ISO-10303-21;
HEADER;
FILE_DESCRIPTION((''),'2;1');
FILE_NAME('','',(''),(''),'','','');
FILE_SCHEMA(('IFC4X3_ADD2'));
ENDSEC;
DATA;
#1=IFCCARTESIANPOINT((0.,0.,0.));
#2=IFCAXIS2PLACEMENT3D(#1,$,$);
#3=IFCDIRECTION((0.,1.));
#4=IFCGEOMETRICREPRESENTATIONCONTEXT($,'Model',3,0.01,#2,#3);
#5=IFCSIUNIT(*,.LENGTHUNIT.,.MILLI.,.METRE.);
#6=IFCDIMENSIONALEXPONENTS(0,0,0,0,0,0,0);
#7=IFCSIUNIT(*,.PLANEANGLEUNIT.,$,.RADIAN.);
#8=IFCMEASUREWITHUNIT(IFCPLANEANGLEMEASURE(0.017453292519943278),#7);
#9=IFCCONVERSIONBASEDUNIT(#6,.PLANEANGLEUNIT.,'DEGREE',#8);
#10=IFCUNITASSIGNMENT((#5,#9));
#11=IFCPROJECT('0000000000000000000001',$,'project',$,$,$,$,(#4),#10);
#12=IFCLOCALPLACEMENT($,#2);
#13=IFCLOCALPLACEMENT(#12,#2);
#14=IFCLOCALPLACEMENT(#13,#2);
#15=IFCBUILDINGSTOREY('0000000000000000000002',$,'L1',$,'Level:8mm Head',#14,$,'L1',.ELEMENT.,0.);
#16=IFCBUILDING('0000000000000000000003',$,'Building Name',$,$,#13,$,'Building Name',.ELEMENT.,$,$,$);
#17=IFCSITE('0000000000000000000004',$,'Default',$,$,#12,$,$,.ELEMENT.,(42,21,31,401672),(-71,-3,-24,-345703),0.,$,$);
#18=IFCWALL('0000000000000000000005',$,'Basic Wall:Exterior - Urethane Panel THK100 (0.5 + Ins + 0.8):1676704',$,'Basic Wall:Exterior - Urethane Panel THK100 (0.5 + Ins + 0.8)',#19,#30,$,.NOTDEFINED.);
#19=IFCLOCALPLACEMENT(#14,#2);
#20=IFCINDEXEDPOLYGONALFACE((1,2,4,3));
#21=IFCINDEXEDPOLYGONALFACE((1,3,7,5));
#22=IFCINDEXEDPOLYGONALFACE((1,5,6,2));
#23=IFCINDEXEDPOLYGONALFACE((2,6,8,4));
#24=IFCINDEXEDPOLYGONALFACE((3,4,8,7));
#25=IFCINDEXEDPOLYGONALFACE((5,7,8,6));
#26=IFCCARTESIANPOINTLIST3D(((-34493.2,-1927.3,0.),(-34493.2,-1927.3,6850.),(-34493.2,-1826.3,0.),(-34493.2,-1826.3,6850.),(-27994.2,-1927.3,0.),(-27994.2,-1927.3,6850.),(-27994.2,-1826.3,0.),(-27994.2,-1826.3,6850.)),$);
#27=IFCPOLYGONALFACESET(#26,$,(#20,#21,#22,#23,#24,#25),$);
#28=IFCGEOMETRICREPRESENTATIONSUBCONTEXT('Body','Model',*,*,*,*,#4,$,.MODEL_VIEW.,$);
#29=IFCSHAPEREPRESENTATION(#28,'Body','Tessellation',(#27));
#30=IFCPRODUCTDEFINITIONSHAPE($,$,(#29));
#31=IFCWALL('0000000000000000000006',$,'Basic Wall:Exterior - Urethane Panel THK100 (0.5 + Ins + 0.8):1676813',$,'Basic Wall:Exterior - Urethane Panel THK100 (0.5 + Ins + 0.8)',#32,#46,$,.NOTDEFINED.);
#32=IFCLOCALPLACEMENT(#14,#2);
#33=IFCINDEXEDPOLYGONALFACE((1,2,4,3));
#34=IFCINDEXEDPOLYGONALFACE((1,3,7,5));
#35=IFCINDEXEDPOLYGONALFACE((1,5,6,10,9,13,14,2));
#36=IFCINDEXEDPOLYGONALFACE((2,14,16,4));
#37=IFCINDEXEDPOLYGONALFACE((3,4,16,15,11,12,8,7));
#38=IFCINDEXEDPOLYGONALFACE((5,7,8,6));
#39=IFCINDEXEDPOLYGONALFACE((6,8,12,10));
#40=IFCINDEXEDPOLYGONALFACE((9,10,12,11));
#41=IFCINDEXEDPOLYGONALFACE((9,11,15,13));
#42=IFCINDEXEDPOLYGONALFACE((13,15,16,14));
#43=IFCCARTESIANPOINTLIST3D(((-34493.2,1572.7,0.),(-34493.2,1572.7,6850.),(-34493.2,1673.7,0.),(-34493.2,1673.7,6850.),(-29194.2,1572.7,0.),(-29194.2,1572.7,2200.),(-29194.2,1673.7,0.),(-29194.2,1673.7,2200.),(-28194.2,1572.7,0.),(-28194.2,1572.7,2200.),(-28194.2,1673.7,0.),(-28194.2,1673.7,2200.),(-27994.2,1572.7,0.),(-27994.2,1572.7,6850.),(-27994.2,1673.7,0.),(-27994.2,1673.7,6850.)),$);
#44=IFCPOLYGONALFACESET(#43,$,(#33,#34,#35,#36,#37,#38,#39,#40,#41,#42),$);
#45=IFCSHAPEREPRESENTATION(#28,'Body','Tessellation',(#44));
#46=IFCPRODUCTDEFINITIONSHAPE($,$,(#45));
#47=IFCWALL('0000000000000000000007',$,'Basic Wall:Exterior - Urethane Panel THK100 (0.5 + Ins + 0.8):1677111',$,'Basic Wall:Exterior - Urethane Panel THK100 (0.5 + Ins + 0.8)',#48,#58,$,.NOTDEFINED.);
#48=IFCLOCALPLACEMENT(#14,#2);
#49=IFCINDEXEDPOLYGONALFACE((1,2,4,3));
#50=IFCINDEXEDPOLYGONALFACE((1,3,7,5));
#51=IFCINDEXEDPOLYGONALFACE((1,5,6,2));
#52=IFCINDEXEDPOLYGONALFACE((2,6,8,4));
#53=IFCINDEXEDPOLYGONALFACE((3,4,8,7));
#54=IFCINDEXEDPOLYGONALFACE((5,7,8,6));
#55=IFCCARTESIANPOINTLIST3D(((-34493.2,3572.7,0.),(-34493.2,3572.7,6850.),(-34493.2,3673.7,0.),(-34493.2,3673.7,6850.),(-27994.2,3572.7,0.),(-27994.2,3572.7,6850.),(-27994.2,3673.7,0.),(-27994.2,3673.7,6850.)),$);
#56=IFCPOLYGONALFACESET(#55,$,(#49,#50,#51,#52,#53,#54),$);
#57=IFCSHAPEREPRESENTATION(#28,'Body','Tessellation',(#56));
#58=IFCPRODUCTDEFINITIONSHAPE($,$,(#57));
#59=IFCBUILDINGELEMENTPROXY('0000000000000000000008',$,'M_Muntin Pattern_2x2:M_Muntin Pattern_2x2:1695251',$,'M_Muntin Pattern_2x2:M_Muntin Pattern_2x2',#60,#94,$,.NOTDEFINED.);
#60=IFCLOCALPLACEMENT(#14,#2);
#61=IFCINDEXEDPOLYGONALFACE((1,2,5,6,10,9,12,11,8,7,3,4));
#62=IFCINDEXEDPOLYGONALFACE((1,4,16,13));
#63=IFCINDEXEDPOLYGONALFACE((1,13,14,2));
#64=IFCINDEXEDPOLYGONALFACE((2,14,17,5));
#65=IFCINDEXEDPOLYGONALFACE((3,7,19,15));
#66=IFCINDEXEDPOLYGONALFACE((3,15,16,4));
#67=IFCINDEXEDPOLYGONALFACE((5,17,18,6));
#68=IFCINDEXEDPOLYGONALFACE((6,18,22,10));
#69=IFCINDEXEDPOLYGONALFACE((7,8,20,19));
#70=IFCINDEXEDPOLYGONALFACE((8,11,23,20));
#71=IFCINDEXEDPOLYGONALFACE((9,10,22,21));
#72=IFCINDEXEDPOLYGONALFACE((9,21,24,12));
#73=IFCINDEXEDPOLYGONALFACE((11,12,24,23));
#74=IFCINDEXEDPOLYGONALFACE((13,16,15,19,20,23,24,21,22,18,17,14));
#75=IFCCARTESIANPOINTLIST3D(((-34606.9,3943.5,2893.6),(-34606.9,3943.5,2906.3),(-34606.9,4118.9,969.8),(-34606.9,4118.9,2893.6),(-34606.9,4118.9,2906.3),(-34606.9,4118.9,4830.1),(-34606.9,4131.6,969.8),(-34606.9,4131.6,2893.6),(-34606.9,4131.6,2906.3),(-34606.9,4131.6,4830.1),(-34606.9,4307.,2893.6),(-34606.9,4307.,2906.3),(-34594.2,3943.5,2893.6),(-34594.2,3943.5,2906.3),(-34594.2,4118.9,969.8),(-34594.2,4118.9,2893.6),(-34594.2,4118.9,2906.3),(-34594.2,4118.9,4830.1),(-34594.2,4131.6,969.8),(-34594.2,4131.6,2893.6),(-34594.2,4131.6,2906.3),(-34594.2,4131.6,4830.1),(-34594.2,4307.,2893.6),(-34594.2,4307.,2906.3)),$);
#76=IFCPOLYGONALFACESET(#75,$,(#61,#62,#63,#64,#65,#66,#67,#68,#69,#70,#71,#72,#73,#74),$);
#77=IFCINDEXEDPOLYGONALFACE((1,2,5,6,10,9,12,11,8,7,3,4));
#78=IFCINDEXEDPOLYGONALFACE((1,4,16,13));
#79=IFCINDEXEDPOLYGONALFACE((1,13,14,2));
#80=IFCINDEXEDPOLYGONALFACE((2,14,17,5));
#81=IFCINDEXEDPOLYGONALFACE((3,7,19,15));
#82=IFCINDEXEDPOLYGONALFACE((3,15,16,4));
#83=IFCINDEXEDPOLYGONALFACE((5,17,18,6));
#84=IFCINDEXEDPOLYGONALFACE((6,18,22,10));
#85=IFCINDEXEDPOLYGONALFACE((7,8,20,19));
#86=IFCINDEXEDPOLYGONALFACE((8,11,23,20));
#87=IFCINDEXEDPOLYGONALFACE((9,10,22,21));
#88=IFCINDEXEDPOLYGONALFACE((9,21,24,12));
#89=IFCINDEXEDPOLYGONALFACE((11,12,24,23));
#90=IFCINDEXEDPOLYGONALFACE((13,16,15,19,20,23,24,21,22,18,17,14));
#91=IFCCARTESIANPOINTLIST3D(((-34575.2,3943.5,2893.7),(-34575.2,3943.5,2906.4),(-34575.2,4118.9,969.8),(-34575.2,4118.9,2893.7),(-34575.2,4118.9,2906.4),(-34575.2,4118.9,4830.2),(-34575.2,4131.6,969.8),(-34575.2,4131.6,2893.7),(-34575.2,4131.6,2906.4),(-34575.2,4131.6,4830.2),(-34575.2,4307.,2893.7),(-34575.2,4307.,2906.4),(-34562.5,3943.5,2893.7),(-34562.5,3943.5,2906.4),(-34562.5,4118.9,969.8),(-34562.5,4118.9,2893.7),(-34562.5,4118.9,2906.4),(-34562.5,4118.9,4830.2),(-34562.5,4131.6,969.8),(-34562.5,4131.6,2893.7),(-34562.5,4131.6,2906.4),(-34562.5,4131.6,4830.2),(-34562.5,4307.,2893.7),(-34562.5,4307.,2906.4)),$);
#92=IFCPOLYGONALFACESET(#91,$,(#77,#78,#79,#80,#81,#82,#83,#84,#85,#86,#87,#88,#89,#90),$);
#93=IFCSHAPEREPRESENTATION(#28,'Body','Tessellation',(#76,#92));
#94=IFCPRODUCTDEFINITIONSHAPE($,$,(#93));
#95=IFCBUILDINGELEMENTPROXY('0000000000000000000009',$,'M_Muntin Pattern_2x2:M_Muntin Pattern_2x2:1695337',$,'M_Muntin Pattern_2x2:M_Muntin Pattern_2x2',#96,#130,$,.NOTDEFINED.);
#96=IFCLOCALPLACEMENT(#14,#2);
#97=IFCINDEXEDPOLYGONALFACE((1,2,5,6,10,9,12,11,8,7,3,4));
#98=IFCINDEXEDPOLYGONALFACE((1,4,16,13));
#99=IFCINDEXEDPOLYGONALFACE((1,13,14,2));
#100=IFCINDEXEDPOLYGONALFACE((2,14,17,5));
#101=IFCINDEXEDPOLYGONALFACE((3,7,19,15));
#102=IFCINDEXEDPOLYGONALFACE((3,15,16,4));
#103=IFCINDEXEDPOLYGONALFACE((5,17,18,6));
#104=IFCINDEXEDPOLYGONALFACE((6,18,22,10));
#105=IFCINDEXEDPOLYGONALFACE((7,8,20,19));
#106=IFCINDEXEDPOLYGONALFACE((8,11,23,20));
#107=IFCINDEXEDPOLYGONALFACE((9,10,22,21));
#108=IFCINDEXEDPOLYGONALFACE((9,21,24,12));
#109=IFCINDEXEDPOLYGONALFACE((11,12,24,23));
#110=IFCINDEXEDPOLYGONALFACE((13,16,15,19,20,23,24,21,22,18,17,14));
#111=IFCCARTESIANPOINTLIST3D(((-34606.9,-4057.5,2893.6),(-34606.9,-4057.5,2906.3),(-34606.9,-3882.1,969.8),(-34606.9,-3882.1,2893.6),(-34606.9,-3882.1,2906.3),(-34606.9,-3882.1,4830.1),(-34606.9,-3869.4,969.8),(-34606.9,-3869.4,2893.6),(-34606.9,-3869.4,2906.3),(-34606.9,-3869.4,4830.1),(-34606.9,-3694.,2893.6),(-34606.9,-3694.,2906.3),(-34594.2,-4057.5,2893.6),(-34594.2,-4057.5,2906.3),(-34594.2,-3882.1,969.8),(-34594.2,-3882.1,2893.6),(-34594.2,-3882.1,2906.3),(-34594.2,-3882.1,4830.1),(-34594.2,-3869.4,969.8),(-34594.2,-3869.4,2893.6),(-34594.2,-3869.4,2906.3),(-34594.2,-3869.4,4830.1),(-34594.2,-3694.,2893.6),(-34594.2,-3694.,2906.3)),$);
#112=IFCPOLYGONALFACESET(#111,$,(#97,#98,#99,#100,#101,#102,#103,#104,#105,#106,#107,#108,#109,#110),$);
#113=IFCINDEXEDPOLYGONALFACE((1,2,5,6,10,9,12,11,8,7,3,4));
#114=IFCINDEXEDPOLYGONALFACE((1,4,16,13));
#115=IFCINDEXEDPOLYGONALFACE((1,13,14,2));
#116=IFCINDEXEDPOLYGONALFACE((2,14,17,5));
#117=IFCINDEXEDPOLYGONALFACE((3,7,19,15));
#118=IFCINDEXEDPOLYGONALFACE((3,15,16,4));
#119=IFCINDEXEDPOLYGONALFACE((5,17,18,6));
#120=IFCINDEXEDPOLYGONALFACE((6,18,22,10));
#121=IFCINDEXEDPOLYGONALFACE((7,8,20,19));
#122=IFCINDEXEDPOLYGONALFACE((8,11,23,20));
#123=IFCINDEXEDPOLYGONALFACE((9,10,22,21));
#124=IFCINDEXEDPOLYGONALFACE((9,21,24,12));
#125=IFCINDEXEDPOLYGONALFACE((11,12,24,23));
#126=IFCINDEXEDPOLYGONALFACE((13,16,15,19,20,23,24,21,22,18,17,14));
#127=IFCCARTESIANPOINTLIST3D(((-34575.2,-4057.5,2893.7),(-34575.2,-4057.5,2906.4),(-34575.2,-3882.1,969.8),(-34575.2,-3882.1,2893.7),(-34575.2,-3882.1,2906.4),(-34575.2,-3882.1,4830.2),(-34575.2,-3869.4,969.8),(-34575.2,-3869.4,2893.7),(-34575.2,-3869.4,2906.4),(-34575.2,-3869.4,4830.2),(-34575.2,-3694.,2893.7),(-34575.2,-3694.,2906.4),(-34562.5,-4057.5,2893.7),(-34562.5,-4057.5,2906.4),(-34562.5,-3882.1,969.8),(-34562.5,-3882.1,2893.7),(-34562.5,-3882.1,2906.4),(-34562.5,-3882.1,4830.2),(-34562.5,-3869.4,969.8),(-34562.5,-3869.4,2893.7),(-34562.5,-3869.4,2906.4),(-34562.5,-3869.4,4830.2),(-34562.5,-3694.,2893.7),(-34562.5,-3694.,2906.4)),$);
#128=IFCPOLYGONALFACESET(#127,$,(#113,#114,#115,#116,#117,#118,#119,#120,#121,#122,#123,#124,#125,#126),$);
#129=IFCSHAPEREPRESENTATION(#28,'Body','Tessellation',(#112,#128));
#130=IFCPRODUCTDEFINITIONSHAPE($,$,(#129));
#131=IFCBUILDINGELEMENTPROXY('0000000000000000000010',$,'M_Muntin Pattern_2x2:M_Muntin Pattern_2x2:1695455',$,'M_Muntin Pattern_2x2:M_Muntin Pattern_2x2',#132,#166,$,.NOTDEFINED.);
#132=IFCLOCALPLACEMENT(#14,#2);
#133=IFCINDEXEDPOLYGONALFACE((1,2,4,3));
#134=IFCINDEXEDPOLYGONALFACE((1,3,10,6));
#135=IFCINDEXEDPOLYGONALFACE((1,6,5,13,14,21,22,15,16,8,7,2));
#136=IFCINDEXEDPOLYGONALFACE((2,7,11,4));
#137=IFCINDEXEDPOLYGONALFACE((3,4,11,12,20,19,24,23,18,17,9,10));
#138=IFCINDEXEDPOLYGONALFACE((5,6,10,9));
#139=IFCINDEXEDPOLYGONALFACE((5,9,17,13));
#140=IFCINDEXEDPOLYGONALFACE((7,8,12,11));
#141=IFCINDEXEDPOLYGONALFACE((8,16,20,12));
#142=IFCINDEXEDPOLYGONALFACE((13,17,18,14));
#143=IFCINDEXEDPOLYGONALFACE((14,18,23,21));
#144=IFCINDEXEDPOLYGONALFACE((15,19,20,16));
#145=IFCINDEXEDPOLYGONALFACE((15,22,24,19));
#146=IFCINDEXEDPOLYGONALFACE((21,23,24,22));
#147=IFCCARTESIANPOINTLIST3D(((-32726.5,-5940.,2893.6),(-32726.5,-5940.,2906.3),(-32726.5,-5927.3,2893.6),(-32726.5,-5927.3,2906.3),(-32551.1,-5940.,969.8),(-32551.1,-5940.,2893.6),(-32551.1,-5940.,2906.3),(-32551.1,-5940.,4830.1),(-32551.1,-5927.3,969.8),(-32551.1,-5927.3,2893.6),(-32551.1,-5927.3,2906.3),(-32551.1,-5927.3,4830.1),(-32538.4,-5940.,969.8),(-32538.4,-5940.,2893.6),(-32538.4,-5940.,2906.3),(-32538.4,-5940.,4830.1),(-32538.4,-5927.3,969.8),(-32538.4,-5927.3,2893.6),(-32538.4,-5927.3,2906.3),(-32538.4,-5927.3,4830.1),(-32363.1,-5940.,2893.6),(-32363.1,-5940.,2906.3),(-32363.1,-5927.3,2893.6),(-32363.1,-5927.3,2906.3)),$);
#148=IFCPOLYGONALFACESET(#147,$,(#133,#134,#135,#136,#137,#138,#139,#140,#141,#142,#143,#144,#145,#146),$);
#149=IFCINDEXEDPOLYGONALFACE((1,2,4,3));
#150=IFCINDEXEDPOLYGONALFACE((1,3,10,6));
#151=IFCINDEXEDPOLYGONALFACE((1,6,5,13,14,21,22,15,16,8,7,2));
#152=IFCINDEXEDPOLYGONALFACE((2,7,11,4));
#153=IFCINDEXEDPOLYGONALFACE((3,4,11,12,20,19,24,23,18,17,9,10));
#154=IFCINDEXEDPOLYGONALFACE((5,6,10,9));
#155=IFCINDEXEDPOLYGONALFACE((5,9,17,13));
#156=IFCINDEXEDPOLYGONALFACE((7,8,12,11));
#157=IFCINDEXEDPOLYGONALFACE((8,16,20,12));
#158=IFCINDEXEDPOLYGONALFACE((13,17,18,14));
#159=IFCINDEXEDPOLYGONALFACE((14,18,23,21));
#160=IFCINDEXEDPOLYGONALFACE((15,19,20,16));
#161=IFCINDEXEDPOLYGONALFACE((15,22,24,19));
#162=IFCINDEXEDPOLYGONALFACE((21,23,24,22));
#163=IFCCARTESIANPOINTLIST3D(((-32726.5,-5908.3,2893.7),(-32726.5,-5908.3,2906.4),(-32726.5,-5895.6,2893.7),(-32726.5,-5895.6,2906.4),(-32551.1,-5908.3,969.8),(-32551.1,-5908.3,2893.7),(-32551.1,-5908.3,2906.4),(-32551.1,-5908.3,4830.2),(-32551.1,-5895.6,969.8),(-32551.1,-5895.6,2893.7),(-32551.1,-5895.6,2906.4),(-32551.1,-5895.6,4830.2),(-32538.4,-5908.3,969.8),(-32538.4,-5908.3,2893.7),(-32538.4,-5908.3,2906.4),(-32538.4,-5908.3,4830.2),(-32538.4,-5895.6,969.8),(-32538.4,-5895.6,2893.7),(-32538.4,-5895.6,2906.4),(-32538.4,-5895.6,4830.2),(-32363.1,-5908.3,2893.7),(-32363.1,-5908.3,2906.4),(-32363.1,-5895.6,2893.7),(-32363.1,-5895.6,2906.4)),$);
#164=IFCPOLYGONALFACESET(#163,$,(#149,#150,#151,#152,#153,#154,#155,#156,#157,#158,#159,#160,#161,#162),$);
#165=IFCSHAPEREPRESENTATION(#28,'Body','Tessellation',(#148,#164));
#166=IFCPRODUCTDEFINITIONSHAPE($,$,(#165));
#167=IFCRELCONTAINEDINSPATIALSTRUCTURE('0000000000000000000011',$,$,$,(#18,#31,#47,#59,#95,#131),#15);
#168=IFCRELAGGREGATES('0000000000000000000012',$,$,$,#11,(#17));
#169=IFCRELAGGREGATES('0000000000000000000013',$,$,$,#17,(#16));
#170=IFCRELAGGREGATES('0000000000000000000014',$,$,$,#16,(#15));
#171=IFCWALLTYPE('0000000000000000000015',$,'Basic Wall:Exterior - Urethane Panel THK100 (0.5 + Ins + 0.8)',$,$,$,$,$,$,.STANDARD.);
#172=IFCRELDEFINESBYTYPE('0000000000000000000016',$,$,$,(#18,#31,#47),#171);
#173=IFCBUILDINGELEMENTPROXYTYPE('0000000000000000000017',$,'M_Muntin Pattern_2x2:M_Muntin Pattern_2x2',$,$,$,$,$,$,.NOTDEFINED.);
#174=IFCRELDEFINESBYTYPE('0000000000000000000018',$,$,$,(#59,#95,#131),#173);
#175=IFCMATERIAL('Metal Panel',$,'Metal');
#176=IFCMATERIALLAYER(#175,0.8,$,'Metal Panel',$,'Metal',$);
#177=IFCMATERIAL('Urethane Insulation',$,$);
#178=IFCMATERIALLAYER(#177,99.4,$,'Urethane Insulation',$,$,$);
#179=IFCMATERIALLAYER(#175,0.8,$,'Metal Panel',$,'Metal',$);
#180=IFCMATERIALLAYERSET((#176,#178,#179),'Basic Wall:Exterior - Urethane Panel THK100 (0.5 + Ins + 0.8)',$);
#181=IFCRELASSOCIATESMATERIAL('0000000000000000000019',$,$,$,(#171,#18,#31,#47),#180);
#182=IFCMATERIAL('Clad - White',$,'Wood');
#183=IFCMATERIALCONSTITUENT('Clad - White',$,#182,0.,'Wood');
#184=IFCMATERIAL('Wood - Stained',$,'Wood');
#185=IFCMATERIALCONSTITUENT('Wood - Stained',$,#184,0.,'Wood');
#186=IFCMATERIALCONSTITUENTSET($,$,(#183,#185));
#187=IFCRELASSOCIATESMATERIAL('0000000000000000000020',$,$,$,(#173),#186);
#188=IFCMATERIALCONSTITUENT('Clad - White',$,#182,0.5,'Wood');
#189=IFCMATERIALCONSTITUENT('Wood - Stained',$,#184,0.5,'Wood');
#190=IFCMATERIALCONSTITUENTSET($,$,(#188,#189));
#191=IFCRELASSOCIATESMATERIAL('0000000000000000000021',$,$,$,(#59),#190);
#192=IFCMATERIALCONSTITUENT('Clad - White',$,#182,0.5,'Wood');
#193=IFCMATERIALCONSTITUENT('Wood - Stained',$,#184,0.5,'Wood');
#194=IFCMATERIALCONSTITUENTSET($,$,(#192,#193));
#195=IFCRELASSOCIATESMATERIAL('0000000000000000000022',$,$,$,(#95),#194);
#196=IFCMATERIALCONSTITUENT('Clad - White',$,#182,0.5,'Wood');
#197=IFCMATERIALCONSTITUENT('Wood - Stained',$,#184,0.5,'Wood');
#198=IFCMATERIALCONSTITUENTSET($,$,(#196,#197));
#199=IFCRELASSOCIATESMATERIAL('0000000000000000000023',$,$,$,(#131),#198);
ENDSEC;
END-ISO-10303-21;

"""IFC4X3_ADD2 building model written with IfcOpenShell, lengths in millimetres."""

from ifc_helpers import new_model, entity, si_unit, converted_unit, direction, frame, frame_2d, origin, place, context, subcontext, project, spatial, polyline, rectangle, outline, extrude, clip, bounded_halfspace, source, transform, mapped, material, layer, layer_set, constituent, constituent_set, type_object, type_shapes, element, save


model = new_model("IFC4X3_ADD2")

# Units and contexts
model_context = context("Model", 3, precision=0.01, world=origin(), true_north=direction((0.0, 1.0)))
body_context = subcontext(model_context, "Body", "Model", "MODEL_VIEW")
ifc_project = project(units=[si_unit("LENGTHUNIT", "METRE", prefix="MILLI"), converted_unit("PLANEANGLEUNIT", "DEGREE", entity("IfcPlaneAngleMeasure", 0.017453292519943278), si_unit("PLANEANGLEUNIT", "RADIAN"), dimensions=[0, 0, 0, 0, 0, 0, 0])], contexts=[model_context])

# Site, building, storey
site_placement = place(None, origin())
site = spatial("IfcSite", under=ifc_project, at=site_placement, Name="Default", CompositionType="ELEMENT", RefLatitude=(42, 21, 31, 401672), RefLongitude=(-71, -3, -24, -345703), RefElevation=0.0)
building_placement = place(site_placement, origin())
building = spatial("IfcBuilding", under=site, at=building_placement, Name="Building Name", LongName="Building Name", CompositionType="ELEMENT")
storey_placement = place(building_placement, origin())
storey = spatial("IfcBuildingStorey", under=building, at=storey_placement, Name="L1", ObjectType="Level:8mm Head", LongName="L1", CompositionType="ELEMENT", Elevation=0.0)

# Shared definitions
ifc_material_1 = material(Name="Metal Panel", Category="Metal")
ifc_layer_1 = layer(ifc_material_1, 0.8, Name="Metal Panel", Category="Metal")
ifc_material_2 = material(Name="Urethane Insulation")
ifc_layer_2 = layer(ifc_material_2, 99.4, Name="Urethane Insulation")
ifc_layer_3 = layer(ifc_material_1, 0.8, Name="Metal Panel", Category="Metal")
ifc_layer_set = layer_set([ifc_layer_1, ifc_layer_2, ifc_layer_3], Name="Basic Wall:Exterior - Urethane Panel THK100 (0.5 + Ins + 0.8)")
wall_type = type_object("IfcWallType", Name="Basic Wall:Exterior - Urethane Panel THK100 (0.5 + Ins + 0.8)", PredefinedType="STANDARD", material=ifc_layer_set)

# Wall
wall_1_placement = place(storey_placement, frame((-34493.2, -1876.8, 0.0)))
element("IfcWall", 1, at=wall_1_placement, inside=storey, type_object=wall_type, material=ifc_layer_set, Name="Basic Wall:Exterior - Urethane Panel THK100 (0.5 + Ins + 0.8):1676704", ObjectType="Basic Wall:Exterior - Urethane Panel THK100 (0.5 + Ins + 0.8)", PredefinedType="NOTDEFINED", context=body_context, shape_type="Clipping", body=[
    clip(extrude(rectangle(XDim=6499.0, YDim=101.0, at=frame_2d((3249.5, 0.0), x_axis=(-1.0, 0.0))), origin(), (0.0, 0.0, 1.0), 6850.0), bounded_halfspace(frame((0.0, -50.5, 6850.0), z_axis=(0.0, 0.0, -1.0), x_axis=(1.0, 0.0, 0.0)), True, frame((0.0, -50.5, 6850.0)), polyline([(0.0, 0.0), (6499.0, 0.0), (6499.0, 101.0), (0.0, 101.0), (0.0, 0.0)]))),
])

# Wall, opening
wall_2_placement = place(storey_placement, frame((-34493.2, 1623.2, 0.0)))
wall_2 = element("IfcWall", 2, at=wall_2_placement, inside=storey, type_object=wall_type, material=ifc_layer_set, Name="Basic Wall:Exterior - Urethane Panel THK100 (0.5 + Ins + 0.8):1676813", ObjectType="Basic Wall:Exterior - Urethane Panel THK100 (0.5 + Ins + 0.8)", PredefinedType="NOTDEFINED", context=body_context, shape_type="Clipping", body=[
    clip(extrude(rectangle(XDim=6499.0, YDim=101.0, at=frame_2d((3249.5, 0.0), x_axis=(1.0, 0.0))), origin(), (0.0, 0.0, 1.0), 6850.0), bounded_halfspace(frame((0.0, -50.5, 6850.0), z_axis=(0.0, 0.0, -1.0), x_axis=(1.0, 0.0, 0.0)), True, frame((0.0, -50.5, 6850.0)), polyline([(0.0, 0.0), (6499.0, 0.0), (6499.0, 101.0), (0.0, 101.0), (0.0, 0.0)]))),
])
opening_1_placement = place(wall_2_placement, frame((5299.0, -50.5, 0.0)))
element("IfcOpeningElement", 3, at=opening_1_placement, cuts=wall_2, PredefinedType="OPENING", context=body_context, shape_type="SweptSolid", body=[
    extrude(rectangle(XDim=2200.0, YDim=1000.0, at=frame_2d((1100.0, 500.0), x_axis=(1.0, 0.0))), frame((0.0, 0.0, 0.0), z_axis=(0.0, 1.0, 0.0), x_axis=(0.0, 0.0, 1.0)), (0.0, 0.0, 1.0), 101.0),
])

# Wall
wall_3_placement = place(storey_placement, frame((-34493.2, 3623.2, 0.0)))
element("IfcWall", 4, at=wall_3_placement, inside=storey, type_object=wall_type, material=ifc_layer_set, Name="Basic Wall:Exterior - Urethane Panel THK100 (0.5 + Ins + 0.8):1677111", ObjectType="Basic Wall:Exterior - Urethane Panel THK100 (0.5 + Ins + 0.8)", PredefinedType="NOTDEFINED", context=body_context, shape_type="Clipping", body=[
    clip(extrude(rectangle(XDim=6499.0, YDim=101.0, at=frame_2d((3249.5, 0.0), x_axis=(-1.0, 0.0))), origin(), (0.0, 0.0, 1.0), 6850.0), bounded_halfspace(frame((0.0, -50.5, 6850.0), z_axis=(0.0, 0.0, -1.0), x_axis=(1.0, 0.0, 0.0)), True, frame((0.0, -50.5, 6850.0)), polyline([(0.0, 0.0), (6499.0, 0.0), (6499.0, 101.0), (0.0, 101.0), (0.0, 0.0)]))),
])

# Building element proxies
ifc_material_3 = material(Name="Clad - White", Category="Wood")
ifc_constituent_1 = constituent(ifc_material_3, Name="Clad - White", Category="Wood", fraction=0.5)
ifc_material_4 = material(Name="Wood - Stained", Category="Wood")
ifc_constituent_2 = constituent(ifc_material_4, Name="Wood - Stained", Category="Wood", fraction=0.5)
ifc_constituent_set_1 = constituent_set(constituents=[ifc_constituent_1, ifc_constituent_2])
ifc_constituent_3 = constituent(ifc_material_3, Name="Clad - White", Category="Wood", fraction=0.0)
ifc_constituent_4 = constituent(ifc_material_4, Name="Wood - Stained", Category="Wood", fraction=0.0)
ifc_constituent_set_2 = constituent_set(constituents=[ifc_constituent_3, ifc_constituent_4])
building_element_proxy_type_1 = type_object("IfcBuildingElementProxyType", Name="M_Muntin Pattern_2x2:M_Muntin Pattern_2x2", PredefinedType="NOTDEFINED", material=ifc_constituent_set_2)
shared_shape_1 = source(origin(), body_context, "Body", "SweptSolid", [
    extrude(outline(polyline([(6.4, -6.4), (1930.1, -6.4), (1930.1, 6.3), (6.4, 6.3), (6.4, 181.7), (-6.3, 181.7), (-6.3, 6.3), (-1930.2, 6.3), (-1930.2, -6.4), (-6.3, -6.4), (-6.3, -181.7), (6.4, -181.7), (6.4, -6.4)])), frame((0.0, 9.5, 1930.1), z_axis=(0.0, 1.0, 0.0), x_axis=(0.0, 0.0, 1.0)), (0.0, 0.0, 1.0), 12.7),
    extrude(outline(polyline([(6.4, -6.4), (1930.2, -6.4), (1930.2, 6.3), (6.4, 6.3), (6.4, 181.7), (-6.3, 181.7), (-6.3, 6.3), (-1930.2, 6.3), (-1930.2, -6.4), (-6.3, -6.4), (-6.3, -181.7), (6.4, -181.7), (6.4, -6.4)])), frame((0.0, -22.2, 1930.2), z_axis=(0.0, 1.0, 0.0), x_axis=(0.0, 0.0, 1.0)), (0.0, 0.0, 1.0), 12.7),
])
type_shapes(building_element_proxy_type_1, [shared_shape_1])
proxy_1_placement = place(storey_placement, frame((-34584.7, 4125.3, 969.8), z_axis=(0.0, 0.0, 1.0), x_axis=(0.0, 1.0, 0.0)))
element("IfcBuildingElementProxy", 5, at=proxy_1_placement, inside=storey, type_object=building_element_proxy_type_1, material=ifc_constituent_set_1, Name="M_Muntin Pattern_2x2:M_Muntin Pattern_2x2:1695251", ObjectType="M_Muntin Pattern_2x2:M_Muntin Pattern_2x2", PredefinedType="NOTDEFINED", context=body_context, shape_type="MappedRepresentation", body=[
    mapped(shared_shape_1, transform((0.0, 0.0, 0.0), scale=1.0)),
])
ifc_constituent_5 = constituent(ifc_material_3, Name="Clad - White", Category="Wood", fraction=0.5)
ifc_constituent_6 = constituent(ifc_material_4, Name="Wood - Stained", Category="Wood", fraction=0.5)
ifc_constituent_set_3 = constituent_set(constituents=[ifc_constituent_5, ifc_constituent_6])
proxy_2_placement = place(storey_placement, frame((-34584.7, -3875.7, 969.8), z_axis=(0.0, 0.0, 1.0), x_axis=(0.0, 1.0, 0.0)))
element("IfcBuildingElementProxy", 6, at=proxy_2_placement, inside=storey, type_object=building_element_proxy_type_1, material=ifc_constituent_set_3, Name="M_Muntin Pattern_2x2:M_Muntin Pattern_2x2:1695337", ObjectType="M_Muntin Pattern_2x2:M_Muntin Pattern_2x2", PredefinedType="NOTDEFINED", context=body_context, shape_type="MappedRepresentation", body=[
    mapped(shared_shape_1, transform((0.0, 0.0, 0.0), scale=1.0)),
])
ifc_constituent_7 = constituent(ifc_material_3, Name="Clad - White", Category="Wood", fraction=0.5)
ifc_constituent_8 = constituent(ifc_material_4, Name="Wood - Stained", Category="Wood", fraction=0.5)
ifc_constituent_set_4 = constituent_set(constituents=[ifc_constituent_7, ifc_constituent_8])
proxy_3_placement = place(storey_placement, frame((-32544.8, -5917.8, 969.8), z_axis=(0.0, 0.0, 1.0), x_axis=(-1.0, 0.0, 0.0)))
element("IfcBuildingElementProxy", 7, at=proxy_3_placement, inside=storey, type_object=building_element_proxy_type_1, material=ifc_constituent_set_4, Name="M_Muntin Pattern_2x2:M_Muntin Pattern_2x2:1695455", ObjectType="M_Muntin Pattern_2x2:M_Muntin Pattern_2x2", PredefinedType="NOTDEFINED", context=body_context, shape_type="MappedRepresentation", body=[
    mapped(shared_shape_1, transform((0.0, 0.0, 0.0), scale=1.0)),
])

save(model, "model.ifc")
